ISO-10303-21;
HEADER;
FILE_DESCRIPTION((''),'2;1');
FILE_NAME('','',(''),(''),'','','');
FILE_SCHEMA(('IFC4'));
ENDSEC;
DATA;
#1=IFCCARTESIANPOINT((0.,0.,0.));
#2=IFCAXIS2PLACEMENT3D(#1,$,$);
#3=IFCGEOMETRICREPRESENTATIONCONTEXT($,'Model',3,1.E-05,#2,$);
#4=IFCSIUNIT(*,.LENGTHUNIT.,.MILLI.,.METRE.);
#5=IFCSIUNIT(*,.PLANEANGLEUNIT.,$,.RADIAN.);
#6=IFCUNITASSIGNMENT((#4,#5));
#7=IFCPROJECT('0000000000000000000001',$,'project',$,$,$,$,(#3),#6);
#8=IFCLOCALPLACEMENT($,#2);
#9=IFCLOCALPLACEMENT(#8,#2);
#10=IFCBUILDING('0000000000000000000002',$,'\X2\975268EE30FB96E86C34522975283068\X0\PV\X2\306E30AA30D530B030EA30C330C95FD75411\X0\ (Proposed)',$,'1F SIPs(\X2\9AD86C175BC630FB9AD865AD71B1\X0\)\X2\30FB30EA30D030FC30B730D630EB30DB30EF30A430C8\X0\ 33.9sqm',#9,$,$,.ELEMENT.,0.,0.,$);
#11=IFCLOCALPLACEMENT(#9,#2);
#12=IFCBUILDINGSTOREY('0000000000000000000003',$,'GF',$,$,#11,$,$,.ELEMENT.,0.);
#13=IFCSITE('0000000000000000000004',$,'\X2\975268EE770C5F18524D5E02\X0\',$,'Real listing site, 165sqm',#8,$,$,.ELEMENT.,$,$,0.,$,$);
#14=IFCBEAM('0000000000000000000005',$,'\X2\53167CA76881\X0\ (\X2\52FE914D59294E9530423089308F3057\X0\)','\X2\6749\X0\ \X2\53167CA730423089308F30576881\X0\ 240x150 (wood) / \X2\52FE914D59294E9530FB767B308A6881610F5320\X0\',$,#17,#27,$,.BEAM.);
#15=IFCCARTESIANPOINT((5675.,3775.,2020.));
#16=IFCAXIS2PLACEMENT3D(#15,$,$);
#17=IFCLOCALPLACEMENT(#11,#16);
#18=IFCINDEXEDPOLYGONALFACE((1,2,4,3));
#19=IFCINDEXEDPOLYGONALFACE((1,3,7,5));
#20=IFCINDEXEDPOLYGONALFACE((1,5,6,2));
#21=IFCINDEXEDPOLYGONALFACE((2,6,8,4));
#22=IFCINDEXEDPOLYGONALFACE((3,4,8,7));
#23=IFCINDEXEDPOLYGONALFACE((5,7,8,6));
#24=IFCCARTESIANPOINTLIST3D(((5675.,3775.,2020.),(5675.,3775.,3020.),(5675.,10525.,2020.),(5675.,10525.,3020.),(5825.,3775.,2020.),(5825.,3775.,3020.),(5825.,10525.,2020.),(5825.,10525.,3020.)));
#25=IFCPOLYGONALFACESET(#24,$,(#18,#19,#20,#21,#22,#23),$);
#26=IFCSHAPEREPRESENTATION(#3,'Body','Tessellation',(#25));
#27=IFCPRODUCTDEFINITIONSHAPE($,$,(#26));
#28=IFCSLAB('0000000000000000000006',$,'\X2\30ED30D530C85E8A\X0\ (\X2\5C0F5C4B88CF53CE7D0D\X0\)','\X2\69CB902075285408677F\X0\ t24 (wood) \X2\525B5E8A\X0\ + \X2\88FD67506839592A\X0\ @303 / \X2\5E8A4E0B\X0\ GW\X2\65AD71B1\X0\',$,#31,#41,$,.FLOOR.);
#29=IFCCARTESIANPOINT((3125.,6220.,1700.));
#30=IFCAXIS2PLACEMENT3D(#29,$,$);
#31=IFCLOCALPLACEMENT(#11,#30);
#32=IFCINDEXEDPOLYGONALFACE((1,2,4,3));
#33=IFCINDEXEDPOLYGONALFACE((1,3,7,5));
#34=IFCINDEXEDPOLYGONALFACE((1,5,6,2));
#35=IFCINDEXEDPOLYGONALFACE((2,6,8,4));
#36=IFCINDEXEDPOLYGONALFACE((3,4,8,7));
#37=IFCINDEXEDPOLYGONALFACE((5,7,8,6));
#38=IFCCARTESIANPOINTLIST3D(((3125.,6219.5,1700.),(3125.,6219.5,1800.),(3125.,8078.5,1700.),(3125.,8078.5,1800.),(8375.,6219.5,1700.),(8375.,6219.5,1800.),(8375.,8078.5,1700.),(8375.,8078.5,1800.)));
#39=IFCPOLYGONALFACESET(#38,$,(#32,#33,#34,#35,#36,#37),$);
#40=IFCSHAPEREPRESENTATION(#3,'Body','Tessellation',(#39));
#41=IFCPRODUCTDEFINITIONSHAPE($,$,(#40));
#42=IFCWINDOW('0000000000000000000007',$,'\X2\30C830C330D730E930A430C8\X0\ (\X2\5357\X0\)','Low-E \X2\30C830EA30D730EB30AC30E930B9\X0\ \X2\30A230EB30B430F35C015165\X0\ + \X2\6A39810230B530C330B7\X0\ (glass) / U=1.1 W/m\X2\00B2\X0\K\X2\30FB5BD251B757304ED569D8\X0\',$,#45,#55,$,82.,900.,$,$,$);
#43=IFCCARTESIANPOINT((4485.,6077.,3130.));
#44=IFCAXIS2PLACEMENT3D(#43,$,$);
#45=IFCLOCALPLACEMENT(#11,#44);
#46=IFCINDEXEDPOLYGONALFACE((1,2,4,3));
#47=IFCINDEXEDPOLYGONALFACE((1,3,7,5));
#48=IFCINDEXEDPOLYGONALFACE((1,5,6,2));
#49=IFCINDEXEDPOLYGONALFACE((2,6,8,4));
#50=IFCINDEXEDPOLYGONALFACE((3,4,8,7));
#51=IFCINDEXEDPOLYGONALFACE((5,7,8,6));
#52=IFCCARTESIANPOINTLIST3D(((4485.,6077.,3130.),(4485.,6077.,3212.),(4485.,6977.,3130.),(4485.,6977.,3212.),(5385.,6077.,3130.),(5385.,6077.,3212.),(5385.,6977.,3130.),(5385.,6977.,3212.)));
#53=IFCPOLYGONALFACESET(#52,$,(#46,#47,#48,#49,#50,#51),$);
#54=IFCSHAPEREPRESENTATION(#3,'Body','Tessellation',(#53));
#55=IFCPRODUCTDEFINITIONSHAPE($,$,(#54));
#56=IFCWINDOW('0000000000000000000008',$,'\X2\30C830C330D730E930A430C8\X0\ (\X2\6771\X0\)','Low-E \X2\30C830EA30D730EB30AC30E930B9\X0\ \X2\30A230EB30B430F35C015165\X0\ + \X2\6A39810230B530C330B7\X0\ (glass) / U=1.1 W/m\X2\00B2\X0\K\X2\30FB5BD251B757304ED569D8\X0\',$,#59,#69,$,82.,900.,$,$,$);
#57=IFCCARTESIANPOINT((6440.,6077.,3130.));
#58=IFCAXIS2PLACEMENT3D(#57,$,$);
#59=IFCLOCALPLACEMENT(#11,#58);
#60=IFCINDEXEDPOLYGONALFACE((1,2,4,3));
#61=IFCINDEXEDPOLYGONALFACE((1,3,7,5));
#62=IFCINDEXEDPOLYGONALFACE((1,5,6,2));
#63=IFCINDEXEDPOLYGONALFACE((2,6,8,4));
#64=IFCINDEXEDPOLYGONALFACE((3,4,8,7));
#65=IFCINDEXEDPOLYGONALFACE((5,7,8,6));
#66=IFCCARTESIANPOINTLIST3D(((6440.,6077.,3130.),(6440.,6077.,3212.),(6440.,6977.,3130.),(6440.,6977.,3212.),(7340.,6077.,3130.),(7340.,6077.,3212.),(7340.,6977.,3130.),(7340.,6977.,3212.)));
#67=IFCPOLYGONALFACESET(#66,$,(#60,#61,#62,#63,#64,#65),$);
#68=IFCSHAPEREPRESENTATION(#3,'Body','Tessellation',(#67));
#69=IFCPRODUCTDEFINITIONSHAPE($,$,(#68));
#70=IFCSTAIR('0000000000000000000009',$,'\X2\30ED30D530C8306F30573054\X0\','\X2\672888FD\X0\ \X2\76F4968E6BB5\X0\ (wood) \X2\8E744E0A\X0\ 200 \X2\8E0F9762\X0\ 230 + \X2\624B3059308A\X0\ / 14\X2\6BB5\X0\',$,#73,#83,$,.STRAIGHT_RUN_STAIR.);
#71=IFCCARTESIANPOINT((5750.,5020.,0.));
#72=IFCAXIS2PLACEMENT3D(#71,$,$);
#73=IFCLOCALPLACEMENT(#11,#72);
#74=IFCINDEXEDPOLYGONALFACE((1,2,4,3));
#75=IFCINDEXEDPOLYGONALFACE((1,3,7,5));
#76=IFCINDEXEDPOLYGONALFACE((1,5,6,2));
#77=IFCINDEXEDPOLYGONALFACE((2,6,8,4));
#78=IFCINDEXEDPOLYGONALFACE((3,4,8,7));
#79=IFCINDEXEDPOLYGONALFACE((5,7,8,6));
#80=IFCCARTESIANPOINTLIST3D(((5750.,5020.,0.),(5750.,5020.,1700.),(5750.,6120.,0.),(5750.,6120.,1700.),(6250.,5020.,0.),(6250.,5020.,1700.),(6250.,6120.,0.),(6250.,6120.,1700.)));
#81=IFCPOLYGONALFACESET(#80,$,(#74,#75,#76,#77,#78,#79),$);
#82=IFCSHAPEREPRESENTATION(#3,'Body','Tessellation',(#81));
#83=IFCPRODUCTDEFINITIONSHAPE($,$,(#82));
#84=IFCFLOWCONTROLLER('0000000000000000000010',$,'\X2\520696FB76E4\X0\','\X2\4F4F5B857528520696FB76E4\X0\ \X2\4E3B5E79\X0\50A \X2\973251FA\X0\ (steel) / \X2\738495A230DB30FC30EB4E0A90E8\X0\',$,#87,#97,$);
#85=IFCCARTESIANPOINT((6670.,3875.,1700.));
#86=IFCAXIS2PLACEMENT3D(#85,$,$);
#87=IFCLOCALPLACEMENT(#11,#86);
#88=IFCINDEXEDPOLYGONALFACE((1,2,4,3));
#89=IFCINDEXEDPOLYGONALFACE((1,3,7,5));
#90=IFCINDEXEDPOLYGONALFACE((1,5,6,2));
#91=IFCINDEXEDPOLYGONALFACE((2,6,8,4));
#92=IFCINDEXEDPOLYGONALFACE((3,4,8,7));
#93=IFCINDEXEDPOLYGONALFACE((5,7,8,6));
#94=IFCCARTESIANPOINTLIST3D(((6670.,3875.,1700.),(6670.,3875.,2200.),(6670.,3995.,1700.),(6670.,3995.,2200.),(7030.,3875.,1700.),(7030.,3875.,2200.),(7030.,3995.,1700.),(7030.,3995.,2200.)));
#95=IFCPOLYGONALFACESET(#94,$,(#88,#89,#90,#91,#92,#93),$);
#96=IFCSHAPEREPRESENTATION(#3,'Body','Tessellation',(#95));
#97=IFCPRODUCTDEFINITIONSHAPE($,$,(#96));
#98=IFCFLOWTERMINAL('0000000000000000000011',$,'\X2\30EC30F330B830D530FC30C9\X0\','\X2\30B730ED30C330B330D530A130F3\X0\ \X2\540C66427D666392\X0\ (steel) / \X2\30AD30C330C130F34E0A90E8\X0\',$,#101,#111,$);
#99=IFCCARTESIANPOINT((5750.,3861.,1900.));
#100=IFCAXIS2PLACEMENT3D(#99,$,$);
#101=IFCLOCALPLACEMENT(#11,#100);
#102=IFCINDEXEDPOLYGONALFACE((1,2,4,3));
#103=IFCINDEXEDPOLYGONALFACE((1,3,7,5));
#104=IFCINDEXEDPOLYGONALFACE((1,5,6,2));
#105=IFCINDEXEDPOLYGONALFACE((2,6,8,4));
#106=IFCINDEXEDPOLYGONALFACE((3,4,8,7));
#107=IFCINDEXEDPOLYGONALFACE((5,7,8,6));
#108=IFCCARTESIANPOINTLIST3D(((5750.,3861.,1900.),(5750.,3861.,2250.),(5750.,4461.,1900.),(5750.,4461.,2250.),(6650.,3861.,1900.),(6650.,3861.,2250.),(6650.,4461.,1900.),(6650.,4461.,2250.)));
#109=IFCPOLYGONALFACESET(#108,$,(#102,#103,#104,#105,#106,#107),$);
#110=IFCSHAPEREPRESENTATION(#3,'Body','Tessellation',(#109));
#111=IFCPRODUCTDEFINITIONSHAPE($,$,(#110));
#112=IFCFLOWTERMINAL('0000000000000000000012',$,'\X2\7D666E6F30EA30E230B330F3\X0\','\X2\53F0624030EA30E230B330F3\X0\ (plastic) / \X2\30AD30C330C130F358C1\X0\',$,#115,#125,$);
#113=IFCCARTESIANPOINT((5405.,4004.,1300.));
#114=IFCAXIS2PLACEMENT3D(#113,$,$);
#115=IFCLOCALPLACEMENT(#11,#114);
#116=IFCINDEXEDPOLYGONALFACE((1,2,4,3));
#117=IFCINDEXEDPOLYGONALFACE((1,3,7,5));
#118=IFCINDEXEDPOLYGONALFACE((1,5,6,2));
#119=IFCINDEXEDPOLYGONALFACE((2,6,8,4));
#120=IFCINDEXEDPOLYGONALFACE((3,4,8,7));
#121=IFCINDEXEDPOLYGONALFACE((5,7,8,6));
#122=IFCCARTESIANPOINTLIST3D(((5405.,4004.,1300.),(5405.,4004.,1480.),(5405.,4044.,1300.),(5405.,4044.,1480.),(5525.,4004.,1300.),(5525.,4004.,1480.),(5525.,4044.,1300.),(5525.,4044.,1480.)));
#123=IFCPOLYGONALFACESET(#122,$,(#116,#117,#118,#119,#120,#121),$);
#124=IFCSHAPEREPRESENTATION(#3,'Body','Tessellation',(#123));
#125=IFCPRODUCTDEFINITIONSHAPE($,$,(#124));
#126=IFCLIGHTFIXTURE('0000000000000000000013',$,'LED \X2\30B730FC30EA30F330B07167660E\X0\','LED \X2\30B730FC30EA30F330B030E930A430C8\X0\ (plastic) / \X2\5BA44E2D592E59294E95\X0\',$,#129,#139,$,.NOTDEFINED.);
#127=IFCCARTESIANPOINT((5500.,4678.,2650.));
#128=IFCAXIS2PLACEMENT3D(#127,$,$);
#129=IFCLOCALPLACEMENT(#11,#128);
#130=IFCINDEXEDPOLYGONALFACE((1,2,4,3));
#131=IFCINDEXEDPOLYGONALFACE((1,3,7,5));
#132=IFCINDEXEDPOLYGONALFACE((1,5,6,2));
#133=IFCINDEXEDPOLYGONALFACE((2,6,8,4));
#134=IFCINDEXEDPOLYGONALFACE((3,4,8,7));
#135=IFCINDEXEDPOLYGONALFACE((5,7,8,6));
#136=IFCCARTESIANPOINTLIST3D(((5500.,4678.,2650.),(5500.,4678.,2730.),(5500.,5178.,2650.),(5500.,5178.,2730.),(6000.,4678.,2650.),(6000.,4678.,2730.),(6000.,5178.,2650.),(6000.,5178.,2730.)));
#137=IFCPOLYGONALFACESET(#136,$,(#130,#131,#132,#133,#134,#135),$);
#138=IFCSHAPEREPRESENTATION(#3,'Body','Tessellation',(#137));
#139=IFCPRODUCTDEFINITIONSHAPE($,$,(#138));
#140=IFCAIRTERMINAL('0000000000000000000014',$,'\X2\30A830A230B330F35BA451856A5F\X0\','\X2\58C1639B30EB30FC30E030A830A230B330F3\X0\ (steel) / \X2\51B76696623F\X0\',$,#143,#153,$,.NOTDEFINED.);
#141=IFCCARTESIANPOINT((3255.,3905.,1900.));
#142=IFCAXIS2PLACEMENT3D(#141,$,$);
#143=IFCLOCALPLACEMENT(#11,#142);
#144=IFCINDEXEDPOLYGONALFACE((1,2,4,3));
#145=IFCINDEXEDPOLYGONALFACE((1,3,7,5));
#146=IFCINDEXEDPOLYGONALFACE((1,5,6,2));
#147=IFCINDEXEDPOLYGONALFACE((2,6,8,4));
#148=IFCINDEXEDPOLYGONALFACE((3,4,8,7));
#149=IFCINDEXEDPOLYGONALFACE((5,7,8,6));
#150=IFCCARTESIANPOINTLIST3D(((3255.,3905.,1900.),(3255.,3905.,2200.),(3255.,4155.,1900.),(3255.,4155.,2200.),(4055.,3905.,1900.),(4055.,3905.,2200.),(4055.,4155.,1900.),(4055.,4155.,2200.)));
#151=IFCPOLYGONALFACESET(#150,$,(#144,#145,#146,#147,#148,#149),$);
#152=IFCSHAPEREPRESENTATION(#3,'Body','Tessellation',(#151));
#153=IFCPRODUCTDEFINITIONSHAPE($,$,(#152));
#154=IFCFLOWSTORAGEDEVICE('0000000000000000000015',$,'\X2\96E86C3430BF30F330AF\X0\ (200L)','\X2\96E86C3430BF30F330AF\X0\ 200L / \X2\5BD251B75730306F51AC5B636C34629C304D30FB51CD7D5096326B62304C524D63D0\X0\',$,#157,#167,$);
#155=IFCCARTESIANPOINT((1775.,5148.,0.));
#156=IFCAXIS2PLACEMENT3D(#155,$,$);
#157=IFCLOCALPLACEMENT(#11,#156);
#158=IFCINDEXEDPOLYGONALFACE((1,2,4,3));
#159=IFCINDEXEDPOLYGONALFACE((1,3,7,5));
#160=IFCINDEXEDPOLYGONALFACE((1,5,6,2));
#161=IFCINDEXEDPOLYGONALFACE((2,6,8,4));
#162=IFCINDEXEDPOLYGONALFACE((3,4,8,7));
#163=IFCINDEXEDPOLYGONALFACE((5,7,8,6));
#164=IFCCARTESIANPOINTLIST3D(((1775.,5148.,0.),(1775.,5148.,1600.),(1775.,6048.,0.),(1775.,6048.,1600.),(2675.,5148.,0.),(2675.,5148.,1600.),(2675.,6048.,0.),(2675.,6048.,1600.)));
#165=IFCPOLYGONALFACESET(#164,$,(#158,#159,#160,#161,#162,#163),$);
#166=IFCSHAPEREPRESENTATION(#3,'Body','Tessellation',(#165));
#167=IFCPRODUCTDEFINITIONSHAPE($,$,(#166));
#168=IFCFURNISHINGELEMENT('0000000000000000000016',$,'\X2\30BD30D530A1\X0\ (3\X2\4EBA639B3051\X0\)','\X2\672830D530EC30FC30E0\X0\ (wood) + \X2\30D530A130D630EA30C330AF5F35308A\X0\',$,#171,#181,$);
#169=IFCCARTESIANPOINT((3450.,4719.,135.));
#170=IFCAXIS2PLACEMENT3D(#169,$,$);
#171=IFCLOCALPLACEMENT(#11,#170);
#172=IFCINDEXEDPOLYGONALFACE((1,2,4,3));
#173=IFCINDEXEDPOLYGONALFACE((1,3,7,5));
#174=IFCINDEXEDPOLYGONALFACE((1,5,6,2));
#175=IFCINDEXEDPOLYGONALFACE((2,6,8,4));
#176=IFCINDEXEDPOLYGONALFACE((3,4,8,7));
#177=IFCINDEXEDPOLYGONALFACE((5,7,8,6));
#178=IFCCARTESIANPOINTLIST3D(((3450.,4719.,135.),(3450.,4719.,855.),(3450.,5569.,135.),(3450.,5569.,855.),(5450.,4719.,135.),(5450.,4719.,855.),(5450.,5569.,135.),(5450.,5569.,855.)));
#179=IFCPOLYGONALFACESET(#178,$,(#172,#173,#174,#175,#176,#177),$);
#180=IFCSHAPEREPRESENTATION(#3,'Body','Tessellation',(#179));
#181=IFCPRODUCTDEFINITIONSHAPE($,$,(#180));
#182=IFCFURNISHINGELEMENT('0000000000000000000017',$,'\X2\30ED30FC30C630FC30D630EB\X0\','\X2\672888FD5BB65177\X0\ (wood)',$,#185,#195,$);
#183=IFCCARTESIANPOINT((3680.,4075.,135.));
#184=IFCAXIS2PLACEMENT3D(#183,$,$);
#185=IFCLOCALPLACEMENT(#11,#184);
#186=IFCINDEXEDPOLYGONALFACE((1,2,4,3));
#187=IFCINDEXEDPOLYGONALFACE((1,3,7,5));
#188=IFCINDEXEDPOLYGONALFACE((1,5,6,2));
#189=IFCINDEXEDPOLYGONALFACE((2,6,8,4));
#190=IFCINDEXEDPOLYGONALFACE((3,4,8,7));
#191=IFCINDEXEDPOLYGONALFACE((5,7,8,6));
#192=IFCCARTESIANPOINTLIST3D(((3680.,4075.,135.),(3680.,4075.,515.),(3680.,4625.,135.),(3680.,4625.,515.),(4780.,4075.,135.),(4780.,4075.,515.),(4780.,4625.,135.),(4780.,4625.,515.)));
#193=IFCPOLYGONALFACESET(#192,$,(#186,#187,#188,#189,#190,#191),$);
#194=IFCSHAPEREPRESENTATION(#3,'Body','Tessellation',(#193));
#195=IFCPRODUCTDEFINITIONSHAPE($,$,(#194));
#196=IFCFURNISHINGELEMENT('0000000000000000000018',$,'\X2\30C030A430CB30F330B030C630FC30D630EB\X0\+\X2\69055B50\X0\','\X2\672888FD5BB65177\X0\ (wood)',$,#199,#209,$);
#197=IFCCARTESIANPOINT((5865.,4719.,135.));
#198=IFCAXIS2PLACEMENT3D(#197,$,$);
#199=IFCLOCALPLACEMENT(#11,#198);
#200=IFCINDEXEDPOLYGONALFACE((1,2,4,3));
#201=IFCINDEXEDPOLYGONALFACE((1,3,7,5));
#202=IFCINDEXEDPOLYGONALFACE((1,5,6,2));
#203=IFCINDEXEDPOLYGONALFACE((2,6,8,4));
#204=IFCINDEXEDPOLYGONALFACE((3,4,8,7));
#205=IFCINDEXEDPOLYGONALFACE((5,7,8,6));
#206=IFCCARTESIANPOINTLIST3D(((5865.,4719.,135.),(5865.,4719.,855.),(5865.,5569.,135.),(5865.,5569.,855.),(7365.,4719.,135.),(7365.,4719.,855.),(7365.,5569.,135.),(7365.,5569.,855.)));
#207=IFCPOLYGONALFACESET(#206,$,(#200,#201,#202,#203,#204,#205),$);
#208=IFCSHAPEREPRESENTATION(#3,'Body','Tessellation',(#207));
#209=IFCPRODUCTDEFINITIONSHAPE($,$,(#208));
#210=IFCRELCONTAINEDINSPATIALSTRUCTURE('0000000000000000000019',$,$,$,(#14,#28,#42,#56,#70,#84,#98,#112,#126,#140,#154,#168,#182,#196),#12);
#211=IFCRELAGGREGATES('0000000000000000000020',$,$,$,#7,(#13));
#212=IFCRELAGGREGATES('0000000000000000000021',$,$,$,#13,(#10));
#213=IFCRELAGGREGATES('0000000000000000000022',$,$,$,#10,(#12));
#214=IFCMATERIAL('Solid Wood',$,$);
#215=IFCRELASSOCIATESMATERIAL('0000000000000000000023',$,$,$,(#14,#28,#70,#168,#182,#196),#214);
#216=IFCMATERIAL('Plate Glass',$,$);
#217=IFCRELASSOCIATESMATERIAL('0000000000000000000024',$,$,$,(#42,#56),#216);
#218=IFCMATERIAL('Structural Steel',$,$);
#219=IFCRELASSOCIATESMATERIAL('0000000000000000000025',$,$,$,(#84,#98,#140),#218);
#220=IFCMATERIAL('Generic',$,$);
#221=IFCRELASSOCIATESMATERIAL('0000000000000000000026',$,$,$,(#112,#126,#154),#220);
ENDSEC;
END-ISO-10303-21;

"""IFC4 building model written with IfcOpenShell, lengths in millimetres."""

from ifc_helpers import new_model, si_unit, frame, frame_2d, origin, place, context, project, spatial, rectangle, extrude, material, element, save


model = new_model("IFC4")

# Units and contexts
model_context = context("Model", 3, precision=1e-05, world=origin())
ifc_project = project(units=[si_unit("LENGTHUNIT", "METRE", prefix="MILLI"), si_unit("PLANEANGLEUNIT", "RADIAN")], contexts=[model_context])

# Site, building, storey
site_placement = place(None, origin())
site = spatial("IfcSite", under=ifc_project, at=site_placement, Name="青森県弘前市", ObjectType="Real listing site, 165sqm", CompositionType="ELEMENT", RefElevation=0.0)
building_placement = place(site_placement, origin())
building = spatial("IfcBuilding", under=site, at=building_placement, Name="青森・雨水利用とPVのオフグリッド志向 (Proposed)", ObjectType="1F SIPs(高気密・高断熱)・リバーシブルホワイト 33.9sqm", CompositionType="ELEMENT", ElevationOfRefHeight=0.0, ElevationOfTerrain=0.0)
storey_placement = place(building_placement, origin())
storey = spatial("IfcBuildingStorey", under=building, at=storey_placement, Name="GF", CompositionType="ELEMENT", Elevation=0.0)

# Shared definitions
ifc_material_1 = material(Name="Solid Wood")

# Beam
beam_placement = place(storey_placement, frame((5675.0, 3775.0, 2020.0)))
element("IfcBeam", 1, at=beam_placement, inside=storey, material=ifc_material_1, Name="化粧梁 (勾配天井あらわし)", Description="杉 化粧あらわし梁 240x150 (wood) / 勾配天井・登り梁意匠", PredefinedType="BEAM", context=model_context, shape_type="SweptSolid", body=[
    extrude(rectangle(XDim=150.0, YDim=6750.0, at=frame_2d((75.0, 3375.0))), frame((5675.0, 3775.0, 2020.0)), (0.0, 0.0, 1.0), 1000.0),
])

# Slab
slab_placement = place(storey_placement, frame((3125.0, 6220.0, 1700.0)))
element("IfcSlab", 2, at=slab_placement, inside=storey, material=ifc_material_1, Name="ロフト床 (小屋裏収納)", Description="構造用合板 t24 (wood) 剛床 + 製材根太 @303 / 床下 GW断熱", PredefinedType="FLOOR", context=model_context, shape_type="SweptSolid", body=[
    extrude(rectangle(XDim=5250.0, YDim=1859.0, at=frame_2d((2625.0, 929.0))), frame((3125.0, 6220.0, 1700.0)), (0.0, 0.0, 1.0), 100.0),
])

# Windows
ifc_material_2 = material(Name="Plate Glass")
window_1_placement = place(storey_placement, frame((4485.0, 6077.0, 3130.0)))
element("IfcWindow", 3, at=window_1_placement, inside=storey, material=ifc_material_2, Name="トップライト (南)", Description="Low-E トリプルガラス アルゴン封入 + 樹脂サッシ (glass) / U=1.1 W/m²K・寒冷地仕様", OverallHeight=82.0, OverallWidth=900.0, context=model_context, shape_type="SweptSolid", body=[
    extrude(rectangle(XDim=900.0, YDim=900.0, at=frame_2d((450.0, 450.0))), frame((4485.0, 6077.0, 3130.0)), (0.0, 0.0, 1.0), 82.0),
])
window_2_placement = place(storey_placement, frame((6440.0, 6077.0, 3130.0)))
element("IfcWindow", 4, at=window_2_placement, inside=storey, material=ifc_material_2, Name="トップライト (東)", Description="Low-E トリプルガラス アルゴン封入 + 樹脂サッシ (glass) / U=1.1 W/m²K・寒冷地仕様", OverallHeight=82.0, OverallWidth=900.0, context=model_context, shape_type="SweptSolid", body=[
    extrude(rectangle(XDim=900.0, YDim=900.0, at=frame_2d((450.0, 450.0))), frame((6440.0, 6077.0, 3130.0)), (0.0, 0.0, 1.0), 82.0),
])

# Stair
stair_placement = place(storey_placement, frame((5750.0, 5020.0, 0.0)))
element("IfcStair", 5, at=stair_placement, inside=storey, material=ifc_material_1, Name="ロフトはしご", Description="木製 直階段 (wood) 蹴上 200 踏面 230 + 手すり / 14段", PredefinedType="STRAIGHT_RUN_STAIR", context=model_context, shape_type="SweptSolid", body=[
    extrude(rectangle(XDim=500.0, YDim=1100.0, at=frame_2d((250.0, 550.0))), frame((5750.0, 5020.0, 0.0)), (0.0, 0.0, 1.0), 1700.0),
])

# Flow controller
ifc_material_3 = material(Name="Structural Steel")
flow_controller_placement = place(storey_placement, frame((6670.0, 3875.0, 1700.0)))
element("IfcFlowController", 6, at=flow_controller_placement, inside=storey, material=ifc_material_3, Name="分電盤", Description="住宅用分電盤 主幹50A 露出 (steel) / 玄関ホール上部", context=model_context, shape_type="SweptSolid", body=[
    extrude(rectangle(XDim=360.0, YDim=120.0, at=frame_2d((180.0, 60.0))), frame((6670.0, 3875.0, 1700.0)), (0.0, 0.0, 1.0), 500.0),
])

# Flow terminals
flow_terminal_1_placement = place(storey_placement, frame((5750.0, 3861.0, 1900.0)))
element("IfcFlowTerminal", 7, at=flow_terminal_1_placement, inside=storey, material=ifc_material_3, Name="レンジフード", Description="シロッコファン 同時給排 (steel) / キッチン上部", context=model_context, shape_type="SweptSolid", body=[
    extrude(rectangle(XDim=900.0, YDim=600.0, at=frame_2d((450.0, 300.0))), frame((5750.0, 3861.0, 1900.0)), (0.0, 0.0, 1.0), 350.0),
])
ifc_material_4 = material(Name="Generic")
flow_terminal_2_placement = place(storey_placement, frame((5405.0, 4004.0, 1300.0)))
element("IfcFlowTerminal", 8, at=flow_terminal_2_placement, inside=storey, material=ifc_material_4, Name="給湯リモコン", Description="台所リモコン (plastic) / キッチン壁", context=model_context, shape_type="SweptSolid", body=[
    extrude(rectangle(XDim=120.0, YDim=40.0, at=frame_2d((60.0, 20.0))), frame((5405.0, 4004.0, 1300.0)), (0.0, 0.0, 1.0), 180.0),
])

# Light fixture
light_fixture_placement = place(storey_placement, frame((5500.0, 4678.0, 2650.0)))
element("IfcLightFixture", 9, at=light_fixture_placement, inside=storey, material=ifc_material_4, Name="LED シーリング照明", Description="LED シーリングライト (plastic) / 室中央天井", PredefinedType="NOTDEFINED", context=model_context, shape_type="SweptSolid", body=[
    extrude(rectangle(XDim=500.0, YDim=500.0, at=frame_2d((250.0, 250.0))), frame((5500.0, 4678.0, 2650.0)), (0.0, 0.0, 1.0), 80.0),
])

# Air terminal
air_terminal_placement = place(storey_placement, frame((3255.0, 3905.0, 1900.0)))
element("IfcAirTerminal", 10, at=air_terminal_placement, inside=storey, material=ifc_material_3, Name="エアコン室内機", Description="壁掛ルームエアコン (steel) / 冷暖房", PredefinedType="NOTDEFINED", context=model_context, shape_type="SweptSolid", body=[
    extrude(rectangle(XDim=800.0, YDim=250.0, at=frame_2d((400.0, 125.0))), frame((3255.0, 3905.0, 1900.0)), (0.0, 0.0, 1.0), 300.0),
])

# Flow storage device
flow_storage_device_placement = place(storey_placement, frame((1775.0, 5148.0, 0.0)))
element("IfcFlowStorageDevice", 11, at=flow_storage_device_placement, inside=storey, material=ifc_material_4, Name="雨水タンク (200L)", Description="雨水タンク 200L / 寒冷地は冬季水抜き・凍結防止が前提", context=model_context, shape_type="SweptSolid", body=[
    extrude(rectangle(XDim=900.0, YDim=900.0, at=frame_2d((450.0, 450.0))), frame((1775.0, 5148.0, 0.0)), (0.0, 0.0, 1.0), 1600.0),
])

# Furnishing elements
furnishing_1_placement = place(storey_placement, frame((3450.0, 4719.0, 135.0)))
element("IfcFurnishingElement", 12, at=furnishing_1_placement, inside=storey, material=ifc_material_1, Name="ソファ (3人掛け)", Description="木フレーム (wood) + ファブリック張り", context=model_context, shape_type="SweptSolid", body=[
    extrude(rectangle(XDim=2000.0, YDim=850.0, at=frame_2d((1000.0, 425.0))), frame((3450.0, 4719.0, 135.0)), (0.0, 0.0, 1.0), 720.0),
])
furnishing_2_placement = place(storey_placement, frame((3680.0, 4075.0, 135.0)))
element("IfcFurnishingElement", 13, at=furnishing_2_placement, inside=storey, material=ifc_material_1, Name="ローテーブル", Description="木製家具 (wood)", context=model_context, shape_type="SweptSolid", body=[
    extrude(rectangle(XDim=1100.0, YDim=550.0, at=frame_2d((550.0, 275.0))), frame((3680.0, 4075.0, 135.0)), (0.0, 0.0, 1.0), 380.0),
])
furnishing_3_placement = place(storey_placement, frame((5865.0, 4719.0, 135.0)))
element("IfcFurnishingElement", 14, at=furnishing_3_placement, inside=storey, material=ifc_material_1, Name="ダイニングテーブル+椅子", Description="木製家具 (wood)", context=model_context, shape_type="SweptSolid", body=[
    extrude(rectangle(XDim=1500.0, YDim=850.0, at=frame_2d((750.0, 425.0))), frame((5865.0, 4719.0, 135.0)), (0.0, 0.0, 1.0), 720.0),
])

save(model, "model.ifc")
